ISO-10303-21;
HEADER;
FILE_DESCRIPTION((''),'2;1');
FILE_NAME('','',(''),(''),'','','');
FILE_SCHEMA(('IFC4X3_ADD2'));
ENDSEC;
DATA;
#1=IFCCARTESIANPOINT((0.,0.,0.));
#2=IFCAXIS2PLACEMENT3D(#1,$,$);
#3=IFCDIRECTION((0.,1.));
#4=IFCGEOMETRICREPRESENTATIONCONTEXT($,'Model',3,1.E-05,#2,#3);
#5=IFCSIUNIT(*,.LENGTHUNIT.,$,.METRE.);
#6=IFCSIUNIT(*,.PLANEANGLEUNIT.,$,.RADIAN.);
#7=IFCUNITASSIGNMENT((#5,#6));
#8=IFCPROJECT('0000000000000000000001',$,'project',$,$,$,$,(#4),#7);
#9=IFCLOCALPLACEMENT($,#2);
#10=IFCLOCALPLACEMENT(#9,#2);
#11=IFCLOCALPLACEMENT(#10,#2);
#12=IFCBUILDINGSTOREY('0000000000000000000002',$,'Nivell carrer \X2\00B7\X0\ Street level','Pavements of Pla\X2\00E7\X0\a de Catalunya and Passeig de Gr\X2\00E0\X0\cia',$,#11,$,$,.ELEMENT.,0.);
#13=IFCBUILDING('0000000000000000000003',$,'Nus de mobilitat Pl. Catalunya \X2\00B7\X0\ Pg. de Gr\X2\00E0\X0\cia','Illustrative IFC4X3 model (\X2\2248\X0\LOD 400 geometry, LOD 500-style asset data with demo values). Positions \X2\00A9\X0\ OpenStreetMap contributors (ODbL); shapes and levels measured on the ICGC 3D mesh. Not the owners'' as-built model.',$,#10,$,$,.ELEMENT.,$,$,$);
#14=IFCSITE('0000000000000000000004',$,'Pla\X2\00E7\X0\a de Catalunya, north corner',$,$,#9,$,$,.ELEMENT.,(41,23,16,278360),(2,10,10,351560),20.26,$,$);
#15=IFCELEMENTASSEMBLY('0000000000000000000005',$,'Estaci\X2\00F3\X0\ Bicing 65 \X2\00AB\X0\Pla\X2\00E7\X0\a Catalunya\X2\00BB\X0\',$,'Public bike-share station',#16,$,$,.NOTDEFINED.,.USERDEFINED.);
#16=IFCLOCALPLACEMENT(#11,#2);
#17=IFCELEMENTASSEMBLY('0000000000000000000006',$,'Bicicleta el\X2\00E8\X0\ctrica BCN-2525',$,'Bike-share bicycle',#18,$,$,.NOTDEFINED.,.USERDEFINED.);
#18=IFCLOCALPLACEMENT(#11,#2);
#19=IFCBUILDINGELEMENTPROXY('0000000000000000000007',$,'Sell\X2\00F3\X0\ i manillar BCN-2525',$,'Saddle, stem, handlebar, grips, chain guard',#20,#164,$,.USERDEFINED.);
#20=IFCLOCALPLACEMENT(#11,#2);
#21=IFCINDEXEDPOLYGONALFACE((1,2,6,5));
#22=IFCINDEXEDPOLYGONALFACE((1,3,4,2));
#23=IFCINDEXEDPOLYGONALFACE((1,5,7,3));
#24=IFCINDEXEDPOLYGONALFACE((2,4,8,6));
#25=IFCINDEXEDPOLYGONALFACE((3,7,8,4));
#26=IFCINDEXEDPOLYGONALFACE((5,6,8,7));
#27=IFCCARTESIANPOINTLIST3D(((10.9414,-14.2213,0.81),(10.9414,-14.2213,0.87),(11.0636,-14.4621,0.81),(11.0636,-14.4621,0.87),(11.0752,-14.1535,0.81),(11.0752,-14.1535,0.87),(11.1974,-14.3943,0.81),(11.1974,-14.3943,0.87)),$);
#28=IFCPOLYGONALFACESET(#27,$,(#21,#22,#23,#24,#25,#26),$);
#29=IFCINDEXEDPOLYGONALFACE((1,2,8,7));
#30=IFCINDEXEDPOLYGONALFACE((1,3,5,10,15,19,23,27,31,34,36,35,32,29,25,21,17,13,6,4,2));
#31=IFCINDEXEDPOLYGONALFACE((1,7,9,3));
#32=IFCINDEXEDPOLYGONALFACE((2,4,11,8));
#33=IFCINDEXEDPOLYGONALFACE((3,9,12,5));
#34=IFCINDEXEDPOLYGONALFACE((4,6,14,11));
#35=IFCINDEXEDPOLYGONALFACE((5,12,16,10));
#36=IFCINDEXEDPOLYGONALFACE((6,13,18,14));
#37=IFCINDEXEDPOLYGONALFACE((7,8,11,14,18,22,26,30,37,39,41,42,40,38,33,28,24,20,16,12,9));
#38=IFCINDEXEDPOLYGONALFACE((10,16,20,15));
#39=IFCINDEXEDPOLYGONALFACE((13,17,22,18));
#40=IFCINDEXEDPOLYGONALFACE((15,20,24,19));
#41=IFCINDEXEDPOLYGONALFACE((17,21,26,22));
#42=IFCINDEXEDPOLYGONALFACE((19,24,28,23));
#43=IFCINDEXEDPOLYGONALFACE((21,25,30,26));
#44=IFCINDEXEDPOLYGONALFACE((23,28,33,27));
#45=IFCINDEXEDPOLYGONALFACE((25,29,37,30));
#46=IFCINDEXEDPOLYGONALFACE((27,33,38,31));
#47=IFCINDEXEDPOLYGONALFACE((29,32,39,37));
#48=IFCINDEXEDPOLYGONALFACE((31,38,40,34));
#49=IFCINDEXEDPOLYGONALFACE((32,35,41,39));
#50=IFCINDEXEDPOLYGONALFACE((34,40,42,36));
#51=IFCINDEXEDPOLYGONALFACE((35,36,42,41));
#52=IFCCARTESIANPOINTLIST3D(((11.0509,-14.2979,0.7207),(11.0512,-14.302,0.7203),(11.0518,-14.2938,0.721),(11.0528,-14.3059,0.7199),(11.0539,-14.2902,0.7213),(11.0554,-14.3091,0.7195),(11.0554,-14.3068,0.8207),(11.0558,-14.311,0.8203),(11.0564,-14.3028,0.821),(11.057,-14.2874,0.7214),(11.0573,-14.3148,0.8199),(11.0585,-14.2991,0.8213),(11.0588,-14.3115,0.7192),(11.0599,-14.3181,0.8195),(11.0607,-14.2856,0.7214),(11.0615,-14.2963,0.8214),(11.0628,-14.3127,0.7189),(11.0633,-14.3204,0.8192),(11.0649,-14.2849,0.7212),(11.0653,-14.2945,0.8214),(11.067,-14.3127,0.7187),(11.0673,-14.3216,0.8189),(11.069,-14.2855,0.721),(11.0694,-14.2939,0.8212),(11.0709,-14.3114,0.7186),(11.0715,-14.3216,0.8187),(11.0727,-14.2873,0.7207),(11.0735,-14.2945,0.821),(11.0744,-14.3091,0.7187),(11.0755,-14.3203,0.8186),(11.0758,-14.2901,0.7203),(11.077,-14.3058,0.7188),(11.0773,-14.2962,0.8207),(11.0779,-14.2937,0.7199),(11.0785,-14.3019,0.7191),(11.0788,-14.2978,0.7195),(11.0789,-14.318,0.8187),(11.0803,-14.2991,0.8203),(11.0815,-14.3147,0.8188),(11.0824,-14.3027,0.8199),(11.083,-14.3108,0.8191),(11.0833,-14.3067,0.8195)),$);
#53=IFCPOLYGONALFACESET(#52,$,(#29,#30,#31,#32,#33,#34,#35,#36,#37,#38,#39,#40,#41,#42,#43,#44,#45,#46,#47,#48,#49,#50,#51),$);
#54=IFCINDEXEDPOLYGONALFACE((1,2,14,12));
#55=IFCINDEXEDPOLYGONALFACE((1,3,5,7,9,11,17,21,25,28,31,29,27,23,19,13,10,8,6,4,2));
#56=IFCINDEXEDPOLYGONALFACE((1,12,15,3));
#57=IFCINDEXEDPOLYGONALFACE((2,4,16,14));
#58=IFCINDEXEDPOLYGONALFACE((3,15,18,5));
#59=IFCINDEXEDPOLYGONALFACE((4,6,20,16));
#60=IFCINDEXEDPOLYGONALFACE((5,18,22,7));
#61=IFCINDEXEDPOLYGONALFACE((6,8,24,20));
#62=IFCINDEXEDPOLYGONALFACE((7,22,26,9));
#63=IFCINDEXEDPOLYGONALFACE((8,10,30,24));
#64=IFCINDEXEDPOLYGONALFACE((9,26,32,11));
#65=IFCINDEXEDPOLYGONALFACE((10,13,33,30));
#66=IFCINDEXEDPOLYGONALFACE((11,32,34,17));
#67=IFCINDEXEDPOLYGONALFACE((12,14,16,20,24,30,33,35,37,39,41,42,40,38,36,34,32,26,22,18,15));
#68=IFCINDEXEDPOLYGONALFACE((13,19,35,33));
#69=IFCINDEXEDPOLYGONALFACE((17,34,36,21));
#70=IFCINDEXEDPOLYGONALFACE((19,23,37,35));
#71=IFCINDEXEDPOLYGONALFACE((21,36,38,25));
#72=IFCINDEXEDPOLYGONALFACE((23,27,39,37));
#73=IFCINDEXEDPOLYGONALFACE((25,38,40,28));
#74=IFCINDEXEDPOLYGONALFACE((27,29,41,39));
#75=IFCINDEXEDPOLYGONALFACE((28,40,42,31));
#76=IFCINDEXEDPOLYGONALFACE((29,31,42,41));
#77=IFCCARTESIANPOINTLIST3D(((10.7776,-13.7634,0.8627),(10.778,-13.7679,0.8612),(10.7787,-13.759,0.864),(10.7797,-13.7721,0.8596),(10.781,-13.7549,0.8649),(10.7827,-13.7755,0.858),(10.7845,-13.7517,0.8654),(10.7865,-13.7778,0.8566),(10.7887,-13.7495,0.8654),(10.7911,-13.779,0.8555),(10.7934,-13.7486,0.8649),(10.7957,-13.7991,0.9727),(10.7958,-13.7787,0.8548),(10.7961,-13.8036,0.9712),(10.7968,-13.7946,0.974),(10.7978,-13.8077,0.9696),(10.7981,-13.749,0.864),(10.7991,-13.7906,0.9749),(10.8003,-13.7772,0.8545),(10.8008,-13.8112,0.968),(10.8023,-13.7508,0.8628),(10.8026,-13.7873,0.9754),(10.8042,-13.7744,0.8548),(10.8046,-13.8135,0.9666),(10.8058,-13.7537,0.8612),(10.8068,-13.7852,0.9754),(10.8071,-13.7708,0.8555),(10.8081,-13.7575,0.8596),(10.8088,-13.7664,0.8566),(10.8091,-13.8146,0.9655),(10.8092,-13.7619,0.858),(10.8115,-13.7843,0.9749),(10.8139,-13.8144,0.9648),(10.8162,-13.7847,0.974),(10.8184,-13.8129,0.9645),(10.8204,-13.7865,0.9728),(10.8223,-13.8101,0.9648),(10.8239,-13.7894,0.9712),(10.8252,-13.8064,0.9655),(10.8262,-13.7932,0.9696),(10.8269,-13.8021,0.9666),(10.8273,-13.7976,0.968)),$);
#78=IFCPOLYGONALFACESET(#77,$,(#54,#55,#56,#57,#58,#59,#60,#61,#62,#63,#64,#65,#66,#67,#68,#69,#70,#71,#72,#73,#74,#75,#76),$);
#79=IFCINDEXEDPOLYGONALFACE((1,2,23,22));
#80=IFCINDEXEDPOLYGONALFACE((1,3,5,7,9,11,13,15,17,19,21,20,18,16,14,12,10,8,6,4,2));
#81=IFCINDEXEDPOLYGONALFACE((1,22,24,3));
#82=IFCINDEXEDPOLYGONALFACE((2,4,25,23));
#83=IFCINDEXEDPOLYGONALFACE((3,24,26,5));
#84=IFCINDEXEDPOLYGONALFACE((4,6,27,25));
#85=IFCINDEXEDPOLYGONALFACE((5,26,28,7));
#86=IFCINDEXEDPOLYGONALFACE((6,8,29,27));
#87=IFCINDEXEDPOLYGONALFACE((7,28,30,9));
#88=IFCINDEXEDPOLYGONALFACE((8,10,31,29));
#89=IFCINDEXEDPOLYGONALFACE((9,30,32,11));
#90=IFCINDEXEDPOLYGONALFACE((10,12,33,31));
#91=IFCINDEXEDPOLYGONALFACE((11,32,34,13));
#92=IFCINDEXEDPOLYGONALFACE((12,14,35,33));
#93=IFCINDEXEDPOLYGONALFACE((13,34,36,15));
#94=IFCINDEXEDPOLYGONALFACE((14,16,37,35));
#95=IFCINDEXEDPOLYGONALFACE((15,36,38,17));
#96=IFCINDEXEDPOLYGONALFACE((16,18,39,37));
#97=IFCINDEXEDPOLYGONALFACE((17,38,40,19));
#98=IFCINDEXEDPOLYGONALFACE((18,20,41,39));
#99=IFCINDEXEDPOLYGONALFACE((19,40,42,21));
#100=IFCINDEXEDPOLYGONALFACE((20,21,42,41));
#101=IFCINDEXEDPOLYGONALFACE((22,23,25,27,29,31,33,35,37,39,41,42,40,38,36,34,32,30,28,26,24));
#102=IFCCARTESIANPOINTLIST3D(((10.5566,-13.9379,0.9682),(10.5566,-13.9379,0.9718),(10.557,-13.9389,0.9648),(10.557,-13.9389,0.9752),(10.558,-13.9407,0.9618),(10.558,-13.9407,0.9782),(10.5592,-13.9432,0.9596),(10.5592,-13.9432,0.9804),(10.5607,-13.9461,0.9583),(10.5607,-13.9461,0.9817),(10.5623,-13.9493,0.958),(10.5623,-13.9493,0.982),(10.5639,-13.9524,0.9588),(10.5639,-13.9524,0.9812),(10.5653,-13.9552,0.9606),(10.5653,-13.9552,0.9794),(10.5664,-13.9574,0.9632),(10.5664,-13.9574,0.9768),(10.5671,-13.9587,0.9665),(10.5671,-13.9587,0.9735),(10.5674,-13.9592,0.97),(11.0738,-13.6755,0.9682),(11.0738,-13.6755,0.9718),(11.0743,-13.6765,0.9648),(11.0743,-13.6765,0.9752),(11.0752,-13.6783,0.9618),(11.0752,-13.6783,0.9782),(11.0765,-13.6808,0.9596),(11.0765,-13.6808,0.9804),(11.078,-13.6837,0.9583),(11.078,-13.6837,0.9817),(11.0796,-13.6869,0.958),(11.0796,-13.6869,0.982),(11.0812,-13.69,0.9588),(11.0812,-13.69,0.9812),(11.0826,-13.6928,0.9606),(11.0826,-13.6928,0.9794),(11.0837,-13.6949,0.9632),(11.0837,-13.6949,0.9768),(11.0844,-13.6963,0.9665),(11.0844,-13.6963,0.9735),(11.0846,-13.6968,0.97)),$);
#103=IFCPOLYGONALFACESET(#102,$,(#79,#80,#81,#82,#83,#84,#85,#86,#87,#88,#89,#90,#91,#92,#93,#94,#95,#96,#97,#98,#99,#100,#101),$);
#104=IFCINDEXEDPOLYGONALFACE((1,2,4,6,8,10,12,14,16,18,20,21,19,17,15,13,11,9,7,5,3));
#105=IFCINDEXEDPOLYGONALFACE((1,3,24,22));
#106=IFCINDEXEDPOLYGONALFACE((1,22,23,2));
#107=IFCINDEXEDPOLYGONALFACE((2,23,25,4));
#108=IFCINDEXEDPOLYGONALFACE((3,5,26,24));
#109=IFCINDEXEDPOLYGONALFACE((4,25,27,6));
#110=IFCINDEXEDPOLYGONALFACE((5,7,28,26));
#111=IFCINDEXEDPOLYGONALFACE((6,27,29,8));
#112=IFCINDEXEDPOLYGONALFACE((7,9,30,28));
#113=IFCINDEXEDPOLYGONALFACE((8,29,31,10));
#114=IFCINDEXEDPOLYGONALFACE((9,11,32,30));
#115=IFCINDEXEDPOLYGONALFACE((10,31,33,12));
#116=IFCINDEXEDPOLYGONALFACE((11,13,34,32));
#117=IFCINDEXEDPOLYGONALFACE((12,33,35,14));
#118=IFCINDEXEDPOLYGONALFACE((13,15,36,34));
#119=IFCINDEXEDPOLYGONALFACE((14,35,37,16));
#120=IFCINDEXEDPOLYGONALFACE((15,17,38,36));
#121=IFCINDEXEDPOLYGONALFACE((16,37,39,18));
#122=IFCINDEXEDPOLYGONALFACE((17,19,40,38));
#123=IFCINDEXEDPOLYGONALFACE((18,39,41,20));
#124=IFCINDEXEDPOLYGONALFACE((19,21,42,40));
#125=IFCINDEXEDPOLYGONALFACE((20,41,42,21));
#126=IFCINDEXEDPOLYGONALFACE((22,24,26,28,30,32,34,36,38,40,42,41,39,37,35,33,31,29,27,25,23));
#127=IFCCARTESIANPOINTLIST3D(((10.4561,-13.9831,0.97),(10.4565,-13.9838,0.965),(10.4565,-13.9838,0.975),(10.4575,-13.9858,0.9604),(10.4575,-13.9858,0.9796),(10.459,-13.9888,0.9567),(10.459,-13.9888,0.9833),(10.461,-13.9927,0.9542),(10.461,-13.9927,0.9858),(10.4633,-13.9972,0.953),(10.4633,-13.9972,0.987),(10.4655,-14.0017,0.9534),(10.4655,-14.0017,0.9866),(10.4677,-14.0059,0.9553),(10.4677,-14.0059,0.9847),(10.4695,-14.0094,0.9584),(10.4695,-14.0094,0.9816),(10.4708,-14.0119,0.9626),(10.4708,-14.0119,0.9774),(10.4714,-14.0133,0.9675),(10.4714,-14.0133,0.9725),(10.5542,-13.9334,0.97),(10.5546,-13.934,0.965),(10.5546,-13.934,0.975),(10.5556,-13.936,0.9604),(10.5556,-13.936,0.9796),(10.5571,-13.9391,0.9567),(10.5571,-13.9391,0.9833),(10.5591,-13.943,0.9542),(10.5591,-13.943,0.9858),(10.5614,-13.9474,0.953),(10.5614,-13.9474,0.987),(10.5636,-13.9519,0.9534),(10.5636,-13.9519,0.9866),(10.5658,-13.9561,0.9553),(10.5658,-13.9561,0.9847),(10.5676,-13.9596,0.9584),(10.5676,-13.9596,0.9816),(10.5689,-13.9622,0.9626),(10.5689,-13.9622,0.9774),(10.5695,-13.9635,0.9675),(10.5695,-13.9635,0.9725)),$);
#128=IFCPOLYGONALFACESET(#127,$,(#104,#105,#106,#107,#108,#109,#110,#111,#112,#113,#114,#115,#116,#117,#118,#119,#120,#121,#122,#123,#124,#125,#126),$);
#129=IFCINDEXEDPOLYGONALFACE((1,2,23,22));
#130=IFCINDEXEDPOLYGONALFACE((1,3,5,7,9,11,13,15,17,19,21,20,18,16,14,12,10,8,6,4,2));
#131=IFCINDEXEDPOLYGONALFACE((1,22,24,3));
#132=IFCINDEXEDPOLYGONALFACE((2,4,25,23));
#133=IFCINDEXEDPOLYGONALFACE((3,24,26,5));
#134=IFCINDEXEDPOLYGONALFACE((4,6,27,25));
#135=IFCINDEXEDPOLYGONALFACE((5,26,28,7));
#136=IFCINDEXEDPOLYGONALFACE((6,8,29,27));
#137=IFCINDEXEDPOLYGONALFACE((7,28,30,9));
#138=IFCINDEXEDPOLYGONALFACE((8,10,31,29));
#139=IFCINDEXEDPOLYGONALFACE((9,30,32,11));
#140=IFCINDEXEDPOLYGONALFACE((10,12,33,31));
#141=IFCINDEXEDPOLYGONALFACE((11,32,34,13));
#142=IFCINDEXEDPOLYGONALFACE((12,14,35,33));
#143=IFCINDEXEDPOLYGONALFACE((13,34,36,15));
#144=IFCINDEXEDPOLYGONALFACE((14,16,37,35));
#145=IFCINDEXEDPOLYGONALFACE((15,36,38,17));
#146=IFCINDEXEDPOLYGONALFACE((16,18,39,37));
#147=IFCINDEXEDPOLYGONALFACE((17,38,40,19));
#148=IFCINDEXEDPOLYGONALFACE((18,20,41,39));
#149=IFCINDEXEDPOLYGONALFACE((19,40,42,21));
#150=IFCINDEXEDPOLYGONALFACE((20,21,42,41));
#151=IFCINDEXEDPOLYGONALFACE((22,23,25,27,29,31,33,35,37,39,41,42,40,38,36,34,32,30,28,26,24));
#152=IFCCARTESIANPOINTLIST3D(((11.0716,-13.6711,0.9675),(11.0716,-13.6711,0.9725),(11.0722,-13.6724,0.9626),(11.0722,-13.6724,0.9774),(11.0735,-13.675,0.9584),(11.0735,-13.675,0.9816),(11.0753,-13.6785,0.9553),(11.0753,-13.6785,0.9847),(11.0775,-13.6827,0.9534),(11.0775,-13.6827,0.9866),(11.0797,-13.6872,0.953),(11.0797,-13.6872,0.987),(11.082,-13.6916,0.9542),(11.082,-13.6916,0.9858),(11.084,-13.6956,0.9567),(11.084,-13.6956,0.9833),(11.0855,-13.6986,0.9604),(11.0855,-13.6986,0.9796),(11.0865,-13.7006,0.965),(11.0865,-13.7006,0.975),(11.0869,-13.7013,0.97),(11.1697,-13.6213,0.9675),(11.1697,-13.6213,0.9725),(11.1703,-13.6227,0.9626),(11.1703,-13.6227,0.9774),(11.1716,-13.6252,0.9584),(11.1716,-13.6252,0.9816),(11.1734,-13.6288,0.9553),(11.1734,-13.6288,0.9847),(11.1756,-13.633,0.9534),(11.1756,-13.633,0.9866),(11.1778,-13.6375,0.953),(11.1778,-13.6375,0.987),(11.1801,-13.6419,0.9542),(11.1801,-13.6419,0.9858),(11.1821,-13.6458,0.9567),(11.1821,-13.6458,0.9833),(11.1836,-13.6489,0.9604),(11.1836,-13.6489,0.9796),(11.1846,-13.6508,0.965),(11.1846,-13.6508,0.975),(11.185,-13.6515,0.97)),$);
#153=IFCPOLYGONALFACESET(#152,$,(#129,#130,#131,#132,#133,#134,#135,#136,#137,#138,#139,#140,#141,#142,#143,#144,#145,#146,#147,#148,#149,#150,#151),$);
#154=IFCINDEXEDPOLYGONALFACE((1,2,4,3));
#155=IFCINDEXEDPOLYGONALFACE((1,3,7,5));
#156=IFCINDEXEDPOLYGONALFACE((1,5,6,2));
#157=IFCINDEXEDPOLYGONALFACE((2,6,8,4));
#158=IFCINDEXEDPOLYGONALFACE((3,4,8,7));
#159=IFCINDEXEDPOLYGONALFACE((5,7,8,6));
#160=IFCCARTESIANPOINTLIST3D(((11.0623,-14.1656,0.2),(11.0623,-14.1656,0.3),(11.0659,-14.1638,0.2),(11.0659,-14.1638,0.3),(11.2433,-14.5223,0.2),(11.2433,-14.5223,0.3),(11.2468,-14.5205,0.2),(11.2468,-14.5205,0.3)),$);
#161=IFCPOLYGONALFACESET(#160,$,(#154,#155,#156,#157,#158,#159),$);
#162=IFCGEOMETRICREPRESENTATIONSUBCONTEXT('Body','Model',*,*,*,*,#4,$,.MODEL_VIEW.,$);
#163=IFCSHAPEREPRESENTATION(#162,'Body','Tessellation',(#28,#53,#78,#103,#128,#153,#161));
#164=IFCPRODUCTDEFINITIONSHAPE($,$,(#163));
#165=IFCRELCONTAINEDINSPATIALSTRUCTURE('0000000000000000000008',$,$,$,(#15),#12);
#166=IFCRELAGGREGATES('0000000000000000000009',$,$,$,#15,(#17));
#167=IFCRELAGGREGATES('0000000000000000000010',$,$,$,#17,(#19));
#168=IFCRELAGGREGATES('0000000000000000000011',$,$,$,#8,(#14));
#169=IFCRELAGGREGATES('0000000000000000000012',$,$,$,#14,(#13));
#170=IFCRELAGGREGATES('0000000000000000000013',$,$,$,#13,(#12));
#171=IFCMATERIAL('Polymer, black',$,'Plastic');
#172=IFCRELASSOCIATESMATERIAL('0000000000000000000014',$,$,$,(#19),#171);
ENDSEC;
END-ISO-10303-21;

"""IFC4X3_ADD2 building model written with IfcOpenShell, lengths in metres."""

from ifc_helpers import new_model, si_unit, direction, frame, origin, origin_2d_with_axis, place, context, subcontext, project, spatial, rectangle, circle, extrude, material, element, aggregate, save


model = new_model("IFC4X3_ADD2")

# Units and contexts
model_context = context("Model", 3, precision=1e-05, world=origin(), true_north=direction((0.0, 1.0)))
body_context = subcontext(model_context, "Body", "Model", "MODEL_VIEW")
ifc_project = project(units=[si_unit("LENGTHUNIT", "METRE"), si_unit("PLANEANGLEUNIT", "RADIAN")], contexts=[model_context])

# Site, building, storey
site_placement = place(None, origin())
site = spatial("IfcSite", under=ifc_project, at=site_placement, Name="Plaça de Catalunya, north corner", CompositionType="ELEMENT", RefLatitude=(41, 23, 16, 278360), RefLongitude=(2, 10, 10, 351560), RefElevation=20.26)
building_placement = place(site_placement, origin())
building = spatial("IfcBuilding", under=site, at=building_placement, Name="Nus de mobilitat Pl. Catalunya · Pg. de Gràcia", Description="Illustrative IFC4X3 model (≈LOD 400 geometry, LOD 500-style asset data with demo values). Positions © OpenStreetMap contributors (ODbL); shapes and levels measured on the ICGC 3D mesh. Not the owners' as-built model.", CompositionType="ELEMENT")
storey_placement = place(building_placement, origin())
storey = spatial("IfcBuildingStorey", under=building, at=storey_placement, Name="Nivell carrer · Street level", Description="Pavements of Plaça de Catalunya and Passeig de Gràcia", CompositionType="ELEMENT", Elevation=0.0)

# Element assemblies, building element proxy
assembly_1_placement = place(building_placement, origin())
assembly_1 = element("IfcElementAssembly", 1, at=assembly_1_placement, inside=storey, Name="Estació Bicing 65 «Plaça Catalunya»", ObjectType="Public bike-share station", AssemblyPlace="NOTDEFINED", PredefinedType="USERDEFINED")
ifc_material_1 = material(Name="Polymer, black", Category="Plastic")
assembly_2_placement = place(building_placement, origin())
assembly_2 = element("IfcElementAssembly", 2, at=assembly_2_placement, Name="Bicicleta elèctrica BCN-2525", ObjectType="Bike-share bicycle", AssemblyPlace="NOTDEFINED", PredefinedType="USERDEFINED")
aggregate(assembly_1, [assembly_2])
proxy_1_placement = place(building_placement, origin())
proxy_1 = element("IfcBuildingElementProxy", 3, at=proxy_1_placement, material=ifc_material_1, Name="Selló i manillar BCN-2525", ObjectType="Saddle, stem, handlebar, grips, chain guard", PredefinedType="USERDEFINED", context=body_context, shape_type="SweptSolid", body=[
    extrude(rectangle(XDim=0.27, YDim=0.15, at=origin_2d_with_axis()), frame((11.0694, -14.3078, 0.87), z_axis=(0.0, 0.0, -1.0), x_axis=(-0.452435, 0.891798, 0.0)), (0.0, 0.0, 1.0), 0.06),
    extrude(circle(Radius=0.014, at=origin_2d_with_axis()), frame((11.0649, -14.2989, 0.72), z_axis=(0.045019, -0.088737, 0.995037), x_axis=(0.0, 0.996047, 0.088827)), (0.0, 0.0, 1.0), 0.1005),
    extrude(circle(Radius=0.016, at=origin_2d_with_axis()), frame((10.7934, -13.7638, 0.86), z_axis=(0.154616, -0.304766, 0.939793), x_axis=(0.0, 0.951232, 0.308475)), (0.0, 0.0, 1.0), 0.117),
    extrude(circle(Radius=0.012, at=origin_2d_with_axis()), frame((10.5619, -13.9485, 0.97), z_axis=(0.891798, 0.452435, 0.0), x_axis=(0.452435, -0.891798, 0.0)), (0.0, 0.0, 1.0), 0.58),
    extrude(circle(Radius=0.017, at=origin_2d_with_axis()), frame((10.5619, -13.9485, 0.97), z_axis=(-0.891798, -0.452435, 0.0), x_axis=(-0.452435, 0.891798, 0.0)), (0.0, 0.0, 1.0), 0.11),
    extrude(circle(Radius=0.017, at=origin_2d_with_axis()), frame((11.0792, -13.6861, 0.97), z_axis=(0.891798, 0.452435, 0.0), x_axis=(0.452435, -0.891798, 0.0)), (0.0, 0.0, 1.0), 0.11),
    extrude(rectangle(XDim=0.4, YDim=0.1, at=origin_2d_with_axis()), frame((11.1528, -14.344, 0.25), z_axis=(0.891798, 0.452435, 0.0), x_axis=(-0.452435, 0.891798, 0.0)), (0.0, 0.0, 1.0), 0.004),
])
aggregate(assembly_2, [proxy_1])

save(model, "model.ifc")
